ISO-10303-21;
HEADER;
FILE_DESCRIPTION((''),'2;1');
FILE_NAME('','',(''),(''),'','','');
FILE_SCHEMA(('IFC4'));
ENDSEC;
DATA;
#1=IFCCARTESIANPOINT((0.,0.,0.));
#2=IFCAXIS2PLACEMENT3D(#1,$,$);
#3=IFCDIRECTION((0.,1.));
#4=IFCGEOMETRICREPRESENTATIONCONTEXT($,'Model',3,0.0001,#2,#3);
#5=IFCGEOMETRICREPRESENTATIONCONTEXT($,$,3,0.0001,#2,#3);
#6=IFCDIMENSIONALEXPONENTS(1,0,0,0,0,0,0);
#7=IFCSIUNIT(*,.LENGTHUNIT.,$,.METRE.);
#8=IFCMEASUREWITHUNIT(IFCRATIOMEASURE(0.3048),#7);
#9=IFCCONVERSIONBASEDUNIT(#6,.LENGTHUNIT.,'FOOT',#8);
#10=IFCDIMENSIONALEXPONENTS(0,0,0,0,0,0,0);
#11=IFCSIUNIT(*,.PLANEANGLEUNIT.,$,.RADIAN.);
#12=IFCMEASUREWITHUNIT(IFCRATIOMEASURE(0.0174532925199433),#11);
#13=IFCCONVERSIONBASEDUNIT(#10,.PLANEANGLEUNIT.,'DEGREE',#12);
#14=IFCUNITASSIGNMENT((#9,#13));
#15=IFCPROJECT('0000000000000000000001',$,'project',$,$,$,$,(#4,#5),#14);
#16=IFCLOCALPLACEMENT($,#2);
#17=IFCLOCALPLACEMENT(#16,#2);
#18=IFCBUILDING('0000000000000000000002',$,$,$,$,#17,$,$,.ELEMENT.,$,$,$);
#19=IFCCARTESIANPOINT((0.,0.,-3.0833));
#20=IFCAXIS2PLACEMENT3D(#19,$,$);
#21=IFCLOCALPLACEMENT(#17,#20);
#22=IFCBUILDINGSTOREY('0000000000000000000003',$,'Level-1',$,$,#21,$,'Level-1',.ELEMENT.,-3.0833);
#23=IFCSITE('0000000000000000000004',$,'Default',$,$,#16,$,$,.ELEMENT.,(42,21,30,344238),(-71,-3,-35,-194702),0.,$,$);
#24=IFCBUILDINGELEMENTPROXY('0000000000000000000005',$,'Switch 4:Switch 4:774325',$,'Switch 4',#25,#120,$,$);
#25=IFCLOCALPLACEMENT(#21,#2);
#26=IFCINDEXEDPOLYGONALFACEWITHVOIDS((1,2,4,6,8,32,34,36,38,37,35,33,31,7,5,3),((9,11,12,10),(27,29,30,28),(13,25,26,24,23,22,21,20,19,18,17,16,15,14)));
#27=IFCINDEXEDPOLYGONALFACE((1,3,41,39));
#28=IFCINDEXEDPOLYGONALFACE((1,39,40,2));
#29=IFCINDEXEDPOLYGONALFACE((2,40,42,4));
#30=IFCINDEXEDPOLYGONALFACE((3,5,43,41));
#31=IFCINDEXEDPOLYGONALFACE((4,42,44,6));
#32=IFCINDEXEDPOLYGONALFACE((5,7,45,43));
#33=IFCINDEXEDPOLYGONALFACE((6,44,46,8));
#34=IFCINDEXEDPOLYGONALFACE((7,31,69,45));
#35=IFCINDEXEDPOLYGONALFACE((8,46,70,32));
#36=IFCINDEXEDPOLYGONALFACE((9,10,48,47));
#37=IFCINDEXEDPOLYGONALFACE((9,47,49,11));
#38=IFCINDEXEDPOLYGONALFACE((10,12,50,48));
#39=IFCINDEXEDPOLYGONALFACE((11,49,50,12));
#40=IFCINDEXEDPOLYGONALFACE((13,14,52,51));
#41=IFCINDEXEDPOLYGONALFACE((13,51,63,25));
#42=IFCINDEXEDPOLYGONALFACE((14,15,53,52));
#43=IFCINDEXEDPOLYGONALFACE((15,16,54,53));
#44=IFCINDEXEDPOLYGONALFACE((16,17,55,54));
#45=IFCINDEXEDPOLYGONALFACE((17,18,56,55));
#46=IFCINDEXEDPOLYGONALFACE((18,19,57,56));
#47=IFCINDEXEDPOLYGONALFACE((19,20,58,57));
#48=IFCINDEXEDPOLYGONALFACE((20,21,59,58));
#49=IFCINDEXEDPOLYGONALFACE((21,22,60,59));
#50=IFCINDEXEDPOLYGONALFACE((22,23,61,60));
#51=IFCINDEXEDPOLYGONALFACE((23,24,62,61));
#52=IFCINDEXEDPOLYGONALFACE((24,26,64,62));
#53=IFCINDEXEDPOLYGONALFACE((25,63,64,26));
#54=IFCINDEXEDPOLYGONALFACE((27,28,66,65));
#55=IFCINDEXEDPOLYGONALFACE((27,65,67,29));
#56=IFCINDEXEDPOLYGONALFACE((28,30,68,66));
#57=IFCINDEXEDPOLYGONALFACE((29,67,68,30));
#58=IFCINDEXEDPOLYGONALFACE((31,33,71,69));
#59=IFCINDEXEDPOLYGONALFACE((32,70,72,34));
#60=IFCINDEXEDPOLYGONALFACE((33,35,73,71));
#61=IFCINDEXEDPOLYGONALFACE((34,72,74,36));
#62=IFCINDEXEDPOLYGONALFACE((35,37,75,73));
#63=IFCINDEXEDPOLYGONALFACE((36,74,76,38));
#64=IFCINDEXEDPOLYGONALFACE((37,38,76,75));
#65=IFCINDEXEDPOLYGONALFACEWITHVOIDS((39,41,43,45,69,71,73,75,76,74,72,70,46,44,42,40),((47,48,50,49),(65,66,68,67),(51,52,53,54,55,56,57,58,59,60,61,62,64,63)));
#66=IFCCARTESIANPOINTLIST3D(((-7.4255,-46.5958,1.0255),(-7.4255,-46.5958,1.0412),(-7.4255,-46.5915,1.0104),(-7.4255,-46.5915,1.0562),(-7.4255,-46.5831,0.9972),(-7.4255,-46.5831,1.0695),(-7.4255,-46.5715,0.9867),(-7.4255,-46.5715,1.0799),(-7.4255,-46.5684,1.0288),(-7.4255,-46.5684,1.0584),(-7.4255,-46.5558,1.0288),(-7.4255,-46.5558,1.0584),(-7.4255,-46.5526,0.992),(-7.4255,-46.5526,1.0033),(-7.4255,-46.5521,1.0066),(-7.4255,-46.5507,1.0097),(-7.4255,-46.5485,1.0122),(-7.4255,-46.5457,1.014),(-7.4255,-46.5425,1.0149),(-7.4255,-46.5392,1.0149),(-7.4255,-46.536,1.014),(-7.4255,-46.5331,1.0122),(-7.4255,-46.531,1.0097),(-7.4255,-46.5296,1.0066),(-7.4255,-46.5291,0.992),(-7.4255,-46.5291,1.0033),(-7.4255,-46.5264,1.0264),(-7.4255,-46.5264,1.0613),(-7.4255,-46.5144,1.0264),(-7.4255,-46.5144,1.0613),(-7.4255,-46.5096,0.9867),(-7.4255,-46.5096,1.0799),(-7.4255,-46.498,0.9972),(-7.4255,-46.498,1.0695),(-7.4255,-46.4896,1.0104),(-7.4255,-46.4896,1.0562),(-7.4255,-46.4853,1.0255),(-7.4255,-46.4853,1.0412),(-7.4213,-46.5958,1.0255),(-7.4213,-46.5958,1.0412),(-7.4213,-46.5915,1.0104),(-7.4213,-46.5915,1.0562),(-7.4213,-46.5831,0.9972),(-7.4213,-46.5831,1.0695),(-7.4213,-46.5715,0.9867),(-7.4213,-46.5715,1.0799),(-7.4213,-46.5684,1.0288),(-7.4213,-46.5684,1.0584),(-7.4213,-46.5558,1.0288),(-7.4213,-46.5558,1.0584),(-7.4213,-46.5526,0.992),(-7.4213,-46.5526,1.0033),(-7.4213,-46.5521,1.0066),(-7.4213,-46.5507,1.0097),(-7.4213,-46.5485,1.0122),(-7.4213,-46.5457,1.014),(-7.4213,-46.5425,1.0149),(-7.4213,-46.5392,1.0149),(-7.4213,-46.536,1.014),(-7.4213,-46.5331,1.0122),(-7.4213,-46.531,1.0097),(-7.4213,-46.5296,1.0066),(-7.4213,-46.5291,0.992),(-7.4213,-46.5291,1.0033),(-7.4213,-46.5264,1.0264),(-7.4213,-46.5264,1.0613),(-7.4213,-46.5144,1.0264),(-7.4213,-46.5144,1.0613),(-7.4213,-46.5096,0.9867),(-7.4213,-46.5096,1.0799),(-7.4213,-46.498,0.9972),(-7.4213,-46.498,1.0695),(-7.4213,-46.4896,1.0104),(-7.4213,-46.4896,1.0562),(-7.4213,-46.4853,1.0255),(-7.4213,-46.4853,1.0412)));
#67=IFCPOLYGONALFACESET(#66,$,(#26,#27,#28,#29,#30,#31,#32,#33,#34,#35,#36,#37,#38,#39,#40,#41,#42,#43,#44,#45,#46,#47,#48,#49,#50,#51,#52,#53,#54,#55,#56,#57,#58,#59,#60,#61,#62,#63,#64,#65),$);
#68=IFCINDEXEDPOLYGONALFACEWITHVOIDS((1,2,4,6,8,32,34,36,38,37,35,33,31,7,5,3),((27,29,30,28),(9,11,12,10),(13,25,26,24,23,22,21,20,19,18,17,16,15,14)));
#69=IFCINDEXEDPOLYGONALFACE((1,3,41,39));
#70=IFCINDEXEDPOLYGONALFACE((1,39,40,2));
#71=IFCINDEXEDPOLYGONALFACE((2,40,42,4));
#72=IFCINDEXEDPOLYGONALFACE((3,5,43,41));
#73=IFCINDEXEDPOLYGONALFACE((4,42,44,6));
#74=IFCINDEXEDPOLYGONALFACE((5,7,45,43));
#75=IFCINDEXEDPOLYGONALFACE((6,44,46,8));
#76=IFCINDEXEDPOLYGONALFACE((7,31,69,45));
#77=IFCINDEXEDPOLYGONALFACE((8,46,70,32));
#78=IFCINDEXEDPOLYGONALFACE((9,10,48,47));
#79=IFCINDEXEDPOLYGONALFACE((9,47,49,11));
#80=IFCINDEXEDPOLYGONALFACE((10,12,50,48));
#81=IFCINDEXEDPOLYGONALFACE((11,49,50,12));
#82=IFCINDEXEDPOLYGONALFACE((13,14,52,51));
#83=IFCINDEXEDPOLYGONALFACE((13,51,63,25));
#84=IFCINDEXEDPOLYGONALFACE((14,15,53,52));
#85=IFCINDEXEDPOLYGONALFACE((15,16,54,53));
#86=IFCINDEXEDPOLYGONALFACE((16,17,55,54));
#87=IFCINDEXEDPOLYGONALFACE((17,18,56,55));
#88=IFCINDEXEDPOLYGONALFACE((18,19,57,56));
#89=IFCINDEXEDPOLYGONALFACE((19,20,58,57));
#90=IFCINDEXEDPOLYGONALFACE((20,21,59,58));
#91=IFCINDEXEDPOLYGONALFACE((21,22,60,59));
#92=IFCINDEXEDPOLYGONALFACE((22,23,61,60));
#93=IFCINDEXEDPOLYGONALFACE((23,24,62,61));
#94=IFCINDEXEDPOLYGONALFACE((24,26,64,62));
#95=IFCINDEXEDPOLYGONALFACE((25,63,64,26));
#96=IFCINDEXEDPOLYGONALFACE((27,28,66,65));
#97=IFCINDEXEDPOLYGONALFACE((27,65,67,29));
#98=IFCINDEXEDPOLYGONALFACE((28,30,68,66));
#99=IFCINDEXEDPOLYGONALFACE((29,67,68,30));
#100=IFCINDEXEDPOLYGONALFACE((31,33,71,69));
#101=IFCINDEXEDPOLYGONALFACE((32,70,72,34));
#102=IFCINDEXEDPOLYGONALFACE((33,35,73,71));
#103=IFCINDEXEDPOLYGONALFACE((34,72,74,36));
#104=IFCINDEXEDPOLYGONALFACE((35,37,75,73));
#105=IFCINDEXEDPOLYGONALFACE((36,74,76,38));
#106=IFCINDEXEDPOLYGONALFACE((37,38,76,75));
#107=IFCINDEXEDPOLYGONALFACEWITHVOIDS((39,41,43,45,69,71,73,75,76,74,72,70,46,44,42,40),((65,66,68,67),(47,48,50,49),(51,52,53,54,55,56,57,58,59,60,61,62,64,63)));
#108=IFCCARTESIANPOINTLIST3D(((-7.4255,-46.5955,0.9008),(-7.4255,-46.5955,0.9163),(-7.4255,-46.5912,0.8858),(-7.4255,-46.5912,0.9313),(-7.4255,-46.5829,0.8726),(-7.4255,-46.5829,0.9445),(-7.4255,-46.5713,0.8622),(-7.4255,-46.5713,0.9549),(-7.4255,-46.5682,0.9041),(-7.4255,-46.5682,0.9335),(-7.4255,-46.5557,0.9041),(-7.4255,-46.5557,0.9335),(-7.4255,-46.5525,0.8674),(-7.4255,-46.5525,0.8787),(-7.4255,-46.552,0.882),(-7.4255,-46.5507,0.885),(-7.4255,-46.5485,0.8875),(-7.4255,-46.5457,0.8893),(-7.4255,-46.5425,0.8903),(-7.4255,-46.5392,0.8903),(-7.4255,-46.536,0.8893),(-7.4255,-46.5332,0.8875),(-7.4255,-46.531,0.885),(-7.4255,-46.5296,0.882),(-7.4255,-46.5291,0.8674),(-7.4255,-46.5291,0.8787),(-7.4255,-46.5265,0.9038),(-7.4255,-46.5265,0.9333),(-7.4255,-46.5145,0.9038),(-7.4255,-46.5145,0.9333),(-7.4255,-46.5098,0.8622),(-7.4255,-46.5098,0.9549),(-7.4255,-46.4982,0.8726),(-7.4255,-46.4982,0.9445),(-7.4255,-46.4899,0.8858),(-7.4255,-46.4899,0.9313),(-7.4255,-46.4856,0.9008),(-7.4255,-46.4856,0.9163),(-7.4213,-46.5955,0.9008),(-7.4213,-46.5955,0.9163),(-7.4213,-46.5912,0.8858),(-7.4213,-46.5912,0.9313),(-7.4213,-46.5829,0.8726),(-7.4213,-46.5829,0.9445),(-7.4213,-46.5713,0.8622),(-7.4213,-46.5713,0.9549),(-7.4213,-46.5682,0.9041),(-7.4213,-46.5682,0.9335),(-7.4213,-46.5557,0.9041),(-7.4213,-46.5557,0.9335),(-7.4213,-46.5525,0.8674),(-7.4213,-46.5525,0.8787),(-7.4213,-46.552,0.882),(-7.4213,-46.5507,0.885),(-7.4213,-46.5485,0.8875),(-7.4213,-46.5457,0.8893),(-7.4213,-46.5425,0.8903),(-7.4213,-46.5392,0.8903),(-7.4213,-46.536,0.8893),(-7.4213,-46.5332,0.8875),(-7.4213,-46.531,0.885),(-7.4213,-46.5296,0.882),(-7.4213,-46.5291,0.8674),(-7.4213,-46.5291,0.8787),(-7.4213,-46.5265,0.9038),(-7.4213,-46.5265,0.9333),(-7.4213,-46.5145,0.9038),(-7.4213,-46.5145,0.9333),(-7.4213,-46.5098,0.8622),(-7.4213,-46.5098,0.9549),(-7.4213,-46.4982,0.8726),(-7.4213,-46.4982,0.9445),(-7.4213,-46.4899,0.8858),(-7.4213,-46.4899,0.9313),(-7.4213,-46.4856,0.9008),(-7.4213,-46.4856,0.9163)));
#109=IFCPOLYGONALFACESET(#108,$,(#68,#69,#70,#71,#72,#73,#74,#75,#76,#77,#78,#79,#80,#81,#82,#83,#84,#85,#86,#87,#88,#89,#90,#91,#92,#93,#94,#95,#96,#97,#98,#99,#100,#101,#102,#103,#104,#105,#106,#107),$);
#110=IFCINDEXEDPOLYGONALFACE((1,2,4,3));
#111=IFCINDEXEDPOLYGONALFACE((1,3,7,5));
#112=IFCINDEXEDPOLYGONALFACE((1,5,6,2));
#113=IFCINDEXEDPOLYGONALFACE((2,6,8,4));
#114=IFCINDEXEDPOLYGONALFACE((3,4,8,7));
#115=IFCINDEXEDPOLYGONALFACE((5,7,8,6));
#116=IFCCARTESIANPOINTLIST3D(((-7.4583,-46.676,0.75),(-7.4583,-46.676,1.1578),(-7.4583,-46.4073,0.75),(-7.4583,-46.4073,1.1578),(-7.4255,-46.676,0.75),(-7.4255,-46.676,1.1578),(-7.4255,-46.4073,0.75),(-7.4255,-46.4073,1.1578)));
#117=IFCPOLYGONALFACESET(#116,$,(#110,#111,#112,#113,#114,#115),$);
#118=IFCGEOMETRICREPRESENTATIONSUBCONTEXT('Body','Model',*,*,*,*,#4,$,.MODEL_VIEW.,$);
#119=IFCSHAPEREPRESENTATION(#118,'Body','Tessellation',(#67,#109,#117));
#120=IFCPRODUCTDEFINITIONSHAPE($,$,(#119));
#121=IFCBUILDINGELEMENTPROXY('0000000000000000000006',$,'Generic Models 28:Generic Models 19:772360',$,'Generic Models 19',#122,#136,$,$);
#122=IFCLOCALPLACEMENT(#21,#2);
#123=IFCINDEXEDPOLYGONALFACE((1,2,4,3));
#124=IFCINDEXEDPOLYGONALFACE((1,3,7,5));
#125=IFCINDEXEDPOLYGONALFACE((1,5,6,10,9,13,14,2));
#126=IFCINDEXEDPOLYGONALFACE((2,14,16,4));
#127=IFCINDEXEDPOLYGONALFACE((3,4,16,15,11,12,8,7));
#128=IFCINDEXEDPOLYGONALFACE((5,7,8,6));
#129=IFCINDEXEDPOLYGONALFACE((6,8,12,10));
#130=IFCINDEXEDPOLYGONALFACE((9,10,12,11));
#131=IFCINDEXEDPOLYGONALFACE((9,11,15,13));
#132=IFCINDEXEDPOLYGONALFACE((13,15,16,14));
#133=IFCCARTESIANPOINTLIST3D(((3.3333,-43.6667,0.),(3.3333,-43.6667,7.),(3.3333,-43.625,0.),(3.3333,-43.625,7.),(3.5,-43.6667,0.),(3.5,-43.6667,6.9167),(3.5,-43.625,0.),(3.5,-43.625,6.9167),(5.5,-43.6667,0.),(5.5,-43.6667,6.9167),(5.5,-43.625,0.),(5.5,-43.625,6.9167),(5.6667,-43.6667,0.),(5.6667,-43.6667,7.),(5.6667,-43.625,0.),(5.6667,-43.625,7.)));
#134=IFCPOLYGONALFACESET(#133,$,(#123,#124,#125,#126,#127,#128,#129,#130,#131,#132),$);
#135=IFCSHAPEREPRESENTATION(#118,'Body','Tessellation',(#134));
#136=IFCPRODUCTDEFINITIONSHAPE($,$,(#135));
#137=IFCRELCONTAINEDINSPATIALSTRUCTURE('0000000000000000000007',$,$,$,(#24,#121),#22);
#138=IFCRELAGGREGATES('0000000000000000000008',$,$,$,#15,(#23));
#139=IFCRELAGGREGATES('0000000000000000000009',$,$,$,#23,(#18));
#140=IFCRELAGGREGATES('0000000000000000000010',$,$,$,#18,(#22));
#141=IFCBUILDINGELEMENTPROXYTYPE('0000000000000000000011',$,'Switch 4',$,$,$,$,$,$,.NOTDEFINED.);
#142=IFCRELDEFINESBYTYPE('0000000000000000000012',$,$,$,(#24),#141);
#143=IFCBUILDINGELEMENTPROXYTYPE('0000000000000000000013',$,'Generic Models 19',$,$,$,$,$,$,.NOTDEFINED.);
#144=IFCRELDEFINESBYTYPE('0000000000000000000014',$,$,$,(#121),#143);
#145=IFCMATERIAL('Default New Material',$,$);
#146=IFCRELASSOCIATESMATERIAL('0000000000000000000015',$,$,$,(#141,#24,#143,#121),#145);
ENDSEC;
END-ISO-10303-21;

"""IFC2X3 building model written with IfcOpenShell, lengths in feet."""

from ifc_helpers import new_model, entity, si_unit, converted_unit, direction, frame, frame_2d, origin, origin_2d_with_axis, place, context, subcontext, project, spatial, polyline, circle_curve, parameter, trimmed, segment, composite_curve, rectangle, outline, extrude, source, transform, mapped, material, type_object, type_shapes, element, save


model = new_model("IFC2X3")

# Units and contexts
model_context = context("Model", 3, precision=0.0001, world=origin(), true_north=direction((0.0, 1.0)))
context_of_model = context(None, 3, precision=0.0001, world=origin(), true_north=direction((0.0, 1.0)))
body_context = subcontext(model_context, "Body", "Model", "MODEL_VIEW")
ifc_project = project(units=[converted_unit("LENGTHUNIT", "FOOT", entity("IfcRatioMeasure", 0.3048), si_unit("LENGTHUNIT", "METRE"), dimensions=[1, 0, 0, 0, 0, 0, 0]), converted_unit("PLANEANGLEUNIT", "DEGREE", entity("IfcRatioMeasure", 0.0174532925199433), si_unit("PLANEANGLEUNIT", "RADIAN"), dimensions=[0, 0, 0, 0, 0, 0, 0])], contexts=[model_context, context_of_model])

# Site, building, storey
site_placement = place(None, origin())
site = spatial("IfcSite", under=ifc_project, at=site_placement, Name="Default", CompositionType="ELEMENT", RefLatitude=(42, 21, 30, 344238), RefLongitude=(-71, -3, -35, -194702), RefElevation=0.0)
building_placement = place(site_placement, origin())
building = spatial("IfcBuilding", under=site, at=building_placement, CompositionType="ELEMENT")
storey_placement = place(building_placement, frame((0.0, 0.0, -3.0833)))
storey = spatial("IfcBuildingStorey", under=building, at=storey_placement, Name="Level-1", LongName="Level-1", CompositionType="ELEMENT", Elevation=-3.0833)

# Shared definitions
ifc_material = material(Name="Default New Material")

# Building element proxies
building_element_proxy_type_1 = type_object("IfcBuildingElementProxyType", Name="Switch 4", PredefinedType="NOTDEFINED", material=ifc_material)
shared_shape_1 = source(origin(), body_context, "Body", "SweptSolid", [
    extrude(outline(composite_curve([segment(polyline([(-0.0309, -0.0466), (0.0309, -0.0466)]), True, "CONTINUOUS"), segment(trimmed(circle_curve(frame_2d((-0.0003, 0.0), x_axis=(-1.0, 0.0)), 0.0561), [parameter(123.794741)], [parameter(236.205259)], True, "PARAMETER"), True, "CONTINUOUS"), segment(polyline([(0.0309, 0.0466), (-0.0309, 0.0466)]), True, "CONTINUOUS"), segment(trimmed(circle_curve(frame_2d((0.0003, 0.0), x_axis=(1.0, 0.0)), 0.0561), [parameter(123.794741)], [parameter(236.205259)], True, "PARAMETER"), True, "CONTINUOUS")], self_intersect=False), holes=[polyline([(0.0142, 0.0279), (0.0262, 0.0279), (0.0262, -0.0069), (0.0142, -0.0069), (0.0142, 0.0279)]), polyline([(-0.0153, 0.025), (-0.0153, -0.0045), (-0.0278, -0.0045), (-0.0278, 0.025), (-0.0153, 0.025)]), composite_curve([segment(polyline([(-0.012, -0.0413), (-0.012, -0.03)]), True, "CONTINUOUS"), segment(trimmed(circle_curve(frame_2d((-0.0003, -0.03), x_axis=(-1.0, 0.0)), 0.0117), [parameter(180.0)], [parameter(0.0)], True, "PARAMETER"), False, "CONTINUOUS"), segment(polyline([(0.0115, -0.03), (0.0115, -0.0413)]), True, "CONTINUOUS"), segment(polyline([(0.0115, -0.0413), (-0.012, -0.0413)]), True, "CONTINUOUS")], self_intersect=False)]), frame((-0.0011, 0.0328, 0.2833), z_axis=(0.0, 1.0, 0.0), x_axis=(-1.0, 0.0, 0.0)), (0.0, 0.0, 1.0), 0.0042),
    extrude(outline(composite_curve([segment(polyline([(-0.0308, -0.0464), (0.0308, -0.0464)]), True, "CONTINUOUS"), segment(trimmed(circle_curve(frame_2d((-0.0003, 0.0), x_axis=(-1.0, 0.0)), 0.0558), [parameter(123.794741)], [parameter(236.205259)], True, "PARAMETER"), True, "CONTINUOUS"), segment(polyline([(0.0308, 0.0464), (-0.0308, 0.0464)]), True, "CONTINUOUS"), segment(trimmed(circle_curve(frame_2d((0.0003, 0.0), x_axis=(1.0, 0.0)), 0.0558), [parameter(123.794741)], [parameter(236.205259)], True, "PARAMETER"), True, "CONTINUOUS")], self_intersect=False), holes=[polyline([(0.0141, 0.0247), (0.026, 0.0247), (0.026, -0.0047), (0.0141, -0.0047), (0.0141, 0.0247)]), polyline([(-0.0152, 0.0249), (-0.0152, -0.0045), (-0.0277, -0.0045), (-0.0277, 0.0249), (-0.0152, 0.0249)]), composite_curve([segment(polyline([(-0.012, -0.0411), (-0.012, -0.0299)]), True, "CONTINUOUS"), segment(trimmed(circle_curve(frame_2d((-0.0003, -0.0299), x_axis=(-1.0, 0.0)), 0.0117), [parameter(180.0)], [parameter(0.0)], True, "PARAMETER"), False, "CONTINUOUS"), segment(polyline([(0.0114, -0.0299), (0.0114, -0.0411)]), True, "CONTINUOUS"), segment(polyline([(0.0114, -0.0411), (-0.012, -0.0411)]), True, "CONTINUOUS")], self_intersect=False)]), frame((-0.0011, 0.0328, 0.1586), z_axis=(0.0, 1.0, 0.0), x_axis=(-1.0, 0.0, 0.0)), (0.0, 0.0, 1.0), 0.0042),
    extrude(rectangle(XDim=0.0328, YDim=0.2687, at=origin_2d_with_axis()), frame((0.0, 0.0164, 0.0), z_axis=(0.0, 0.0, 1.0), x_axis=(0.0, -1.0, 0.0)), (0.0, 0.0, 1.0), 0.4078),
])
type_shapes(building_element_proxy_type_1, [shared_shape_1])
proxy_1_placement = place(storey_placement, frame((-7.4583, -46.5417, 0.75), z_axis=(0.0, 0.0, 1.0), x_axis=(0.0, -1.0, 0.0)))
element("IfcBuildingElementProxy", 1, at=proxy_1_placement, inside=storey, type_object=building_element_proxy_type_1, material=ifc_material, Name="Switch 4:Switch 4:774325", ObjectType="Switch 4", context=body_context, shape_type="MappedRepresentation", body=[
    mapped(shared_shape_1, transform((0.0, 0.0, 0.0), scale=1.0)),
])
building_element_proxy_type_2 = type_object("IfcBuildingElementProxyType", Name="Generic Models 19", PredefinedType="NOTDEFINED", material=ifc_material)
shared_shape_2 = source(origin(), body_context, "Body", "SweptSolid", [
    extrude(outline(polyline([(-3.4792, -1.0), (-3.4792, -1.1667), (3.5208, -1.1667), (3.5208, 1.1667), (-3.4792, 1.1667), (-3.4792, 1.0), (3.4375, 1.0), (3.4375, -1.0), (-3.4792, -1.0)])), frame((1.1667, 0.0, 3.4792), z_axis=(0.0, -1.0, 0.0), x_axis=(0.0, 0.0, 1.0)), (0.0, 0.0, -1.0), 0.0417),
])
type_shapes(building_element_proxy_type_2, [shared_shape_2])
proxy_2_placement = place(storey_placement, frame((3.3333, -43.6667, 0.0)))
element("IfcBuildingElementProxy", 2, at=proxy_2_placement, inside=storey, type_object=building_element_proxy_type_2, material=ifc_material, Name="Generic Models 28:Generic Models 19:772360", ObjectType="Generic Models 19", context=body_context, shape_type="MappedRepresentation", body=[
    mapped(shared_shape_2, transform((0.0, 0.0, 0.0), scale=1.0)),
])

save(model, "model.ifc")
